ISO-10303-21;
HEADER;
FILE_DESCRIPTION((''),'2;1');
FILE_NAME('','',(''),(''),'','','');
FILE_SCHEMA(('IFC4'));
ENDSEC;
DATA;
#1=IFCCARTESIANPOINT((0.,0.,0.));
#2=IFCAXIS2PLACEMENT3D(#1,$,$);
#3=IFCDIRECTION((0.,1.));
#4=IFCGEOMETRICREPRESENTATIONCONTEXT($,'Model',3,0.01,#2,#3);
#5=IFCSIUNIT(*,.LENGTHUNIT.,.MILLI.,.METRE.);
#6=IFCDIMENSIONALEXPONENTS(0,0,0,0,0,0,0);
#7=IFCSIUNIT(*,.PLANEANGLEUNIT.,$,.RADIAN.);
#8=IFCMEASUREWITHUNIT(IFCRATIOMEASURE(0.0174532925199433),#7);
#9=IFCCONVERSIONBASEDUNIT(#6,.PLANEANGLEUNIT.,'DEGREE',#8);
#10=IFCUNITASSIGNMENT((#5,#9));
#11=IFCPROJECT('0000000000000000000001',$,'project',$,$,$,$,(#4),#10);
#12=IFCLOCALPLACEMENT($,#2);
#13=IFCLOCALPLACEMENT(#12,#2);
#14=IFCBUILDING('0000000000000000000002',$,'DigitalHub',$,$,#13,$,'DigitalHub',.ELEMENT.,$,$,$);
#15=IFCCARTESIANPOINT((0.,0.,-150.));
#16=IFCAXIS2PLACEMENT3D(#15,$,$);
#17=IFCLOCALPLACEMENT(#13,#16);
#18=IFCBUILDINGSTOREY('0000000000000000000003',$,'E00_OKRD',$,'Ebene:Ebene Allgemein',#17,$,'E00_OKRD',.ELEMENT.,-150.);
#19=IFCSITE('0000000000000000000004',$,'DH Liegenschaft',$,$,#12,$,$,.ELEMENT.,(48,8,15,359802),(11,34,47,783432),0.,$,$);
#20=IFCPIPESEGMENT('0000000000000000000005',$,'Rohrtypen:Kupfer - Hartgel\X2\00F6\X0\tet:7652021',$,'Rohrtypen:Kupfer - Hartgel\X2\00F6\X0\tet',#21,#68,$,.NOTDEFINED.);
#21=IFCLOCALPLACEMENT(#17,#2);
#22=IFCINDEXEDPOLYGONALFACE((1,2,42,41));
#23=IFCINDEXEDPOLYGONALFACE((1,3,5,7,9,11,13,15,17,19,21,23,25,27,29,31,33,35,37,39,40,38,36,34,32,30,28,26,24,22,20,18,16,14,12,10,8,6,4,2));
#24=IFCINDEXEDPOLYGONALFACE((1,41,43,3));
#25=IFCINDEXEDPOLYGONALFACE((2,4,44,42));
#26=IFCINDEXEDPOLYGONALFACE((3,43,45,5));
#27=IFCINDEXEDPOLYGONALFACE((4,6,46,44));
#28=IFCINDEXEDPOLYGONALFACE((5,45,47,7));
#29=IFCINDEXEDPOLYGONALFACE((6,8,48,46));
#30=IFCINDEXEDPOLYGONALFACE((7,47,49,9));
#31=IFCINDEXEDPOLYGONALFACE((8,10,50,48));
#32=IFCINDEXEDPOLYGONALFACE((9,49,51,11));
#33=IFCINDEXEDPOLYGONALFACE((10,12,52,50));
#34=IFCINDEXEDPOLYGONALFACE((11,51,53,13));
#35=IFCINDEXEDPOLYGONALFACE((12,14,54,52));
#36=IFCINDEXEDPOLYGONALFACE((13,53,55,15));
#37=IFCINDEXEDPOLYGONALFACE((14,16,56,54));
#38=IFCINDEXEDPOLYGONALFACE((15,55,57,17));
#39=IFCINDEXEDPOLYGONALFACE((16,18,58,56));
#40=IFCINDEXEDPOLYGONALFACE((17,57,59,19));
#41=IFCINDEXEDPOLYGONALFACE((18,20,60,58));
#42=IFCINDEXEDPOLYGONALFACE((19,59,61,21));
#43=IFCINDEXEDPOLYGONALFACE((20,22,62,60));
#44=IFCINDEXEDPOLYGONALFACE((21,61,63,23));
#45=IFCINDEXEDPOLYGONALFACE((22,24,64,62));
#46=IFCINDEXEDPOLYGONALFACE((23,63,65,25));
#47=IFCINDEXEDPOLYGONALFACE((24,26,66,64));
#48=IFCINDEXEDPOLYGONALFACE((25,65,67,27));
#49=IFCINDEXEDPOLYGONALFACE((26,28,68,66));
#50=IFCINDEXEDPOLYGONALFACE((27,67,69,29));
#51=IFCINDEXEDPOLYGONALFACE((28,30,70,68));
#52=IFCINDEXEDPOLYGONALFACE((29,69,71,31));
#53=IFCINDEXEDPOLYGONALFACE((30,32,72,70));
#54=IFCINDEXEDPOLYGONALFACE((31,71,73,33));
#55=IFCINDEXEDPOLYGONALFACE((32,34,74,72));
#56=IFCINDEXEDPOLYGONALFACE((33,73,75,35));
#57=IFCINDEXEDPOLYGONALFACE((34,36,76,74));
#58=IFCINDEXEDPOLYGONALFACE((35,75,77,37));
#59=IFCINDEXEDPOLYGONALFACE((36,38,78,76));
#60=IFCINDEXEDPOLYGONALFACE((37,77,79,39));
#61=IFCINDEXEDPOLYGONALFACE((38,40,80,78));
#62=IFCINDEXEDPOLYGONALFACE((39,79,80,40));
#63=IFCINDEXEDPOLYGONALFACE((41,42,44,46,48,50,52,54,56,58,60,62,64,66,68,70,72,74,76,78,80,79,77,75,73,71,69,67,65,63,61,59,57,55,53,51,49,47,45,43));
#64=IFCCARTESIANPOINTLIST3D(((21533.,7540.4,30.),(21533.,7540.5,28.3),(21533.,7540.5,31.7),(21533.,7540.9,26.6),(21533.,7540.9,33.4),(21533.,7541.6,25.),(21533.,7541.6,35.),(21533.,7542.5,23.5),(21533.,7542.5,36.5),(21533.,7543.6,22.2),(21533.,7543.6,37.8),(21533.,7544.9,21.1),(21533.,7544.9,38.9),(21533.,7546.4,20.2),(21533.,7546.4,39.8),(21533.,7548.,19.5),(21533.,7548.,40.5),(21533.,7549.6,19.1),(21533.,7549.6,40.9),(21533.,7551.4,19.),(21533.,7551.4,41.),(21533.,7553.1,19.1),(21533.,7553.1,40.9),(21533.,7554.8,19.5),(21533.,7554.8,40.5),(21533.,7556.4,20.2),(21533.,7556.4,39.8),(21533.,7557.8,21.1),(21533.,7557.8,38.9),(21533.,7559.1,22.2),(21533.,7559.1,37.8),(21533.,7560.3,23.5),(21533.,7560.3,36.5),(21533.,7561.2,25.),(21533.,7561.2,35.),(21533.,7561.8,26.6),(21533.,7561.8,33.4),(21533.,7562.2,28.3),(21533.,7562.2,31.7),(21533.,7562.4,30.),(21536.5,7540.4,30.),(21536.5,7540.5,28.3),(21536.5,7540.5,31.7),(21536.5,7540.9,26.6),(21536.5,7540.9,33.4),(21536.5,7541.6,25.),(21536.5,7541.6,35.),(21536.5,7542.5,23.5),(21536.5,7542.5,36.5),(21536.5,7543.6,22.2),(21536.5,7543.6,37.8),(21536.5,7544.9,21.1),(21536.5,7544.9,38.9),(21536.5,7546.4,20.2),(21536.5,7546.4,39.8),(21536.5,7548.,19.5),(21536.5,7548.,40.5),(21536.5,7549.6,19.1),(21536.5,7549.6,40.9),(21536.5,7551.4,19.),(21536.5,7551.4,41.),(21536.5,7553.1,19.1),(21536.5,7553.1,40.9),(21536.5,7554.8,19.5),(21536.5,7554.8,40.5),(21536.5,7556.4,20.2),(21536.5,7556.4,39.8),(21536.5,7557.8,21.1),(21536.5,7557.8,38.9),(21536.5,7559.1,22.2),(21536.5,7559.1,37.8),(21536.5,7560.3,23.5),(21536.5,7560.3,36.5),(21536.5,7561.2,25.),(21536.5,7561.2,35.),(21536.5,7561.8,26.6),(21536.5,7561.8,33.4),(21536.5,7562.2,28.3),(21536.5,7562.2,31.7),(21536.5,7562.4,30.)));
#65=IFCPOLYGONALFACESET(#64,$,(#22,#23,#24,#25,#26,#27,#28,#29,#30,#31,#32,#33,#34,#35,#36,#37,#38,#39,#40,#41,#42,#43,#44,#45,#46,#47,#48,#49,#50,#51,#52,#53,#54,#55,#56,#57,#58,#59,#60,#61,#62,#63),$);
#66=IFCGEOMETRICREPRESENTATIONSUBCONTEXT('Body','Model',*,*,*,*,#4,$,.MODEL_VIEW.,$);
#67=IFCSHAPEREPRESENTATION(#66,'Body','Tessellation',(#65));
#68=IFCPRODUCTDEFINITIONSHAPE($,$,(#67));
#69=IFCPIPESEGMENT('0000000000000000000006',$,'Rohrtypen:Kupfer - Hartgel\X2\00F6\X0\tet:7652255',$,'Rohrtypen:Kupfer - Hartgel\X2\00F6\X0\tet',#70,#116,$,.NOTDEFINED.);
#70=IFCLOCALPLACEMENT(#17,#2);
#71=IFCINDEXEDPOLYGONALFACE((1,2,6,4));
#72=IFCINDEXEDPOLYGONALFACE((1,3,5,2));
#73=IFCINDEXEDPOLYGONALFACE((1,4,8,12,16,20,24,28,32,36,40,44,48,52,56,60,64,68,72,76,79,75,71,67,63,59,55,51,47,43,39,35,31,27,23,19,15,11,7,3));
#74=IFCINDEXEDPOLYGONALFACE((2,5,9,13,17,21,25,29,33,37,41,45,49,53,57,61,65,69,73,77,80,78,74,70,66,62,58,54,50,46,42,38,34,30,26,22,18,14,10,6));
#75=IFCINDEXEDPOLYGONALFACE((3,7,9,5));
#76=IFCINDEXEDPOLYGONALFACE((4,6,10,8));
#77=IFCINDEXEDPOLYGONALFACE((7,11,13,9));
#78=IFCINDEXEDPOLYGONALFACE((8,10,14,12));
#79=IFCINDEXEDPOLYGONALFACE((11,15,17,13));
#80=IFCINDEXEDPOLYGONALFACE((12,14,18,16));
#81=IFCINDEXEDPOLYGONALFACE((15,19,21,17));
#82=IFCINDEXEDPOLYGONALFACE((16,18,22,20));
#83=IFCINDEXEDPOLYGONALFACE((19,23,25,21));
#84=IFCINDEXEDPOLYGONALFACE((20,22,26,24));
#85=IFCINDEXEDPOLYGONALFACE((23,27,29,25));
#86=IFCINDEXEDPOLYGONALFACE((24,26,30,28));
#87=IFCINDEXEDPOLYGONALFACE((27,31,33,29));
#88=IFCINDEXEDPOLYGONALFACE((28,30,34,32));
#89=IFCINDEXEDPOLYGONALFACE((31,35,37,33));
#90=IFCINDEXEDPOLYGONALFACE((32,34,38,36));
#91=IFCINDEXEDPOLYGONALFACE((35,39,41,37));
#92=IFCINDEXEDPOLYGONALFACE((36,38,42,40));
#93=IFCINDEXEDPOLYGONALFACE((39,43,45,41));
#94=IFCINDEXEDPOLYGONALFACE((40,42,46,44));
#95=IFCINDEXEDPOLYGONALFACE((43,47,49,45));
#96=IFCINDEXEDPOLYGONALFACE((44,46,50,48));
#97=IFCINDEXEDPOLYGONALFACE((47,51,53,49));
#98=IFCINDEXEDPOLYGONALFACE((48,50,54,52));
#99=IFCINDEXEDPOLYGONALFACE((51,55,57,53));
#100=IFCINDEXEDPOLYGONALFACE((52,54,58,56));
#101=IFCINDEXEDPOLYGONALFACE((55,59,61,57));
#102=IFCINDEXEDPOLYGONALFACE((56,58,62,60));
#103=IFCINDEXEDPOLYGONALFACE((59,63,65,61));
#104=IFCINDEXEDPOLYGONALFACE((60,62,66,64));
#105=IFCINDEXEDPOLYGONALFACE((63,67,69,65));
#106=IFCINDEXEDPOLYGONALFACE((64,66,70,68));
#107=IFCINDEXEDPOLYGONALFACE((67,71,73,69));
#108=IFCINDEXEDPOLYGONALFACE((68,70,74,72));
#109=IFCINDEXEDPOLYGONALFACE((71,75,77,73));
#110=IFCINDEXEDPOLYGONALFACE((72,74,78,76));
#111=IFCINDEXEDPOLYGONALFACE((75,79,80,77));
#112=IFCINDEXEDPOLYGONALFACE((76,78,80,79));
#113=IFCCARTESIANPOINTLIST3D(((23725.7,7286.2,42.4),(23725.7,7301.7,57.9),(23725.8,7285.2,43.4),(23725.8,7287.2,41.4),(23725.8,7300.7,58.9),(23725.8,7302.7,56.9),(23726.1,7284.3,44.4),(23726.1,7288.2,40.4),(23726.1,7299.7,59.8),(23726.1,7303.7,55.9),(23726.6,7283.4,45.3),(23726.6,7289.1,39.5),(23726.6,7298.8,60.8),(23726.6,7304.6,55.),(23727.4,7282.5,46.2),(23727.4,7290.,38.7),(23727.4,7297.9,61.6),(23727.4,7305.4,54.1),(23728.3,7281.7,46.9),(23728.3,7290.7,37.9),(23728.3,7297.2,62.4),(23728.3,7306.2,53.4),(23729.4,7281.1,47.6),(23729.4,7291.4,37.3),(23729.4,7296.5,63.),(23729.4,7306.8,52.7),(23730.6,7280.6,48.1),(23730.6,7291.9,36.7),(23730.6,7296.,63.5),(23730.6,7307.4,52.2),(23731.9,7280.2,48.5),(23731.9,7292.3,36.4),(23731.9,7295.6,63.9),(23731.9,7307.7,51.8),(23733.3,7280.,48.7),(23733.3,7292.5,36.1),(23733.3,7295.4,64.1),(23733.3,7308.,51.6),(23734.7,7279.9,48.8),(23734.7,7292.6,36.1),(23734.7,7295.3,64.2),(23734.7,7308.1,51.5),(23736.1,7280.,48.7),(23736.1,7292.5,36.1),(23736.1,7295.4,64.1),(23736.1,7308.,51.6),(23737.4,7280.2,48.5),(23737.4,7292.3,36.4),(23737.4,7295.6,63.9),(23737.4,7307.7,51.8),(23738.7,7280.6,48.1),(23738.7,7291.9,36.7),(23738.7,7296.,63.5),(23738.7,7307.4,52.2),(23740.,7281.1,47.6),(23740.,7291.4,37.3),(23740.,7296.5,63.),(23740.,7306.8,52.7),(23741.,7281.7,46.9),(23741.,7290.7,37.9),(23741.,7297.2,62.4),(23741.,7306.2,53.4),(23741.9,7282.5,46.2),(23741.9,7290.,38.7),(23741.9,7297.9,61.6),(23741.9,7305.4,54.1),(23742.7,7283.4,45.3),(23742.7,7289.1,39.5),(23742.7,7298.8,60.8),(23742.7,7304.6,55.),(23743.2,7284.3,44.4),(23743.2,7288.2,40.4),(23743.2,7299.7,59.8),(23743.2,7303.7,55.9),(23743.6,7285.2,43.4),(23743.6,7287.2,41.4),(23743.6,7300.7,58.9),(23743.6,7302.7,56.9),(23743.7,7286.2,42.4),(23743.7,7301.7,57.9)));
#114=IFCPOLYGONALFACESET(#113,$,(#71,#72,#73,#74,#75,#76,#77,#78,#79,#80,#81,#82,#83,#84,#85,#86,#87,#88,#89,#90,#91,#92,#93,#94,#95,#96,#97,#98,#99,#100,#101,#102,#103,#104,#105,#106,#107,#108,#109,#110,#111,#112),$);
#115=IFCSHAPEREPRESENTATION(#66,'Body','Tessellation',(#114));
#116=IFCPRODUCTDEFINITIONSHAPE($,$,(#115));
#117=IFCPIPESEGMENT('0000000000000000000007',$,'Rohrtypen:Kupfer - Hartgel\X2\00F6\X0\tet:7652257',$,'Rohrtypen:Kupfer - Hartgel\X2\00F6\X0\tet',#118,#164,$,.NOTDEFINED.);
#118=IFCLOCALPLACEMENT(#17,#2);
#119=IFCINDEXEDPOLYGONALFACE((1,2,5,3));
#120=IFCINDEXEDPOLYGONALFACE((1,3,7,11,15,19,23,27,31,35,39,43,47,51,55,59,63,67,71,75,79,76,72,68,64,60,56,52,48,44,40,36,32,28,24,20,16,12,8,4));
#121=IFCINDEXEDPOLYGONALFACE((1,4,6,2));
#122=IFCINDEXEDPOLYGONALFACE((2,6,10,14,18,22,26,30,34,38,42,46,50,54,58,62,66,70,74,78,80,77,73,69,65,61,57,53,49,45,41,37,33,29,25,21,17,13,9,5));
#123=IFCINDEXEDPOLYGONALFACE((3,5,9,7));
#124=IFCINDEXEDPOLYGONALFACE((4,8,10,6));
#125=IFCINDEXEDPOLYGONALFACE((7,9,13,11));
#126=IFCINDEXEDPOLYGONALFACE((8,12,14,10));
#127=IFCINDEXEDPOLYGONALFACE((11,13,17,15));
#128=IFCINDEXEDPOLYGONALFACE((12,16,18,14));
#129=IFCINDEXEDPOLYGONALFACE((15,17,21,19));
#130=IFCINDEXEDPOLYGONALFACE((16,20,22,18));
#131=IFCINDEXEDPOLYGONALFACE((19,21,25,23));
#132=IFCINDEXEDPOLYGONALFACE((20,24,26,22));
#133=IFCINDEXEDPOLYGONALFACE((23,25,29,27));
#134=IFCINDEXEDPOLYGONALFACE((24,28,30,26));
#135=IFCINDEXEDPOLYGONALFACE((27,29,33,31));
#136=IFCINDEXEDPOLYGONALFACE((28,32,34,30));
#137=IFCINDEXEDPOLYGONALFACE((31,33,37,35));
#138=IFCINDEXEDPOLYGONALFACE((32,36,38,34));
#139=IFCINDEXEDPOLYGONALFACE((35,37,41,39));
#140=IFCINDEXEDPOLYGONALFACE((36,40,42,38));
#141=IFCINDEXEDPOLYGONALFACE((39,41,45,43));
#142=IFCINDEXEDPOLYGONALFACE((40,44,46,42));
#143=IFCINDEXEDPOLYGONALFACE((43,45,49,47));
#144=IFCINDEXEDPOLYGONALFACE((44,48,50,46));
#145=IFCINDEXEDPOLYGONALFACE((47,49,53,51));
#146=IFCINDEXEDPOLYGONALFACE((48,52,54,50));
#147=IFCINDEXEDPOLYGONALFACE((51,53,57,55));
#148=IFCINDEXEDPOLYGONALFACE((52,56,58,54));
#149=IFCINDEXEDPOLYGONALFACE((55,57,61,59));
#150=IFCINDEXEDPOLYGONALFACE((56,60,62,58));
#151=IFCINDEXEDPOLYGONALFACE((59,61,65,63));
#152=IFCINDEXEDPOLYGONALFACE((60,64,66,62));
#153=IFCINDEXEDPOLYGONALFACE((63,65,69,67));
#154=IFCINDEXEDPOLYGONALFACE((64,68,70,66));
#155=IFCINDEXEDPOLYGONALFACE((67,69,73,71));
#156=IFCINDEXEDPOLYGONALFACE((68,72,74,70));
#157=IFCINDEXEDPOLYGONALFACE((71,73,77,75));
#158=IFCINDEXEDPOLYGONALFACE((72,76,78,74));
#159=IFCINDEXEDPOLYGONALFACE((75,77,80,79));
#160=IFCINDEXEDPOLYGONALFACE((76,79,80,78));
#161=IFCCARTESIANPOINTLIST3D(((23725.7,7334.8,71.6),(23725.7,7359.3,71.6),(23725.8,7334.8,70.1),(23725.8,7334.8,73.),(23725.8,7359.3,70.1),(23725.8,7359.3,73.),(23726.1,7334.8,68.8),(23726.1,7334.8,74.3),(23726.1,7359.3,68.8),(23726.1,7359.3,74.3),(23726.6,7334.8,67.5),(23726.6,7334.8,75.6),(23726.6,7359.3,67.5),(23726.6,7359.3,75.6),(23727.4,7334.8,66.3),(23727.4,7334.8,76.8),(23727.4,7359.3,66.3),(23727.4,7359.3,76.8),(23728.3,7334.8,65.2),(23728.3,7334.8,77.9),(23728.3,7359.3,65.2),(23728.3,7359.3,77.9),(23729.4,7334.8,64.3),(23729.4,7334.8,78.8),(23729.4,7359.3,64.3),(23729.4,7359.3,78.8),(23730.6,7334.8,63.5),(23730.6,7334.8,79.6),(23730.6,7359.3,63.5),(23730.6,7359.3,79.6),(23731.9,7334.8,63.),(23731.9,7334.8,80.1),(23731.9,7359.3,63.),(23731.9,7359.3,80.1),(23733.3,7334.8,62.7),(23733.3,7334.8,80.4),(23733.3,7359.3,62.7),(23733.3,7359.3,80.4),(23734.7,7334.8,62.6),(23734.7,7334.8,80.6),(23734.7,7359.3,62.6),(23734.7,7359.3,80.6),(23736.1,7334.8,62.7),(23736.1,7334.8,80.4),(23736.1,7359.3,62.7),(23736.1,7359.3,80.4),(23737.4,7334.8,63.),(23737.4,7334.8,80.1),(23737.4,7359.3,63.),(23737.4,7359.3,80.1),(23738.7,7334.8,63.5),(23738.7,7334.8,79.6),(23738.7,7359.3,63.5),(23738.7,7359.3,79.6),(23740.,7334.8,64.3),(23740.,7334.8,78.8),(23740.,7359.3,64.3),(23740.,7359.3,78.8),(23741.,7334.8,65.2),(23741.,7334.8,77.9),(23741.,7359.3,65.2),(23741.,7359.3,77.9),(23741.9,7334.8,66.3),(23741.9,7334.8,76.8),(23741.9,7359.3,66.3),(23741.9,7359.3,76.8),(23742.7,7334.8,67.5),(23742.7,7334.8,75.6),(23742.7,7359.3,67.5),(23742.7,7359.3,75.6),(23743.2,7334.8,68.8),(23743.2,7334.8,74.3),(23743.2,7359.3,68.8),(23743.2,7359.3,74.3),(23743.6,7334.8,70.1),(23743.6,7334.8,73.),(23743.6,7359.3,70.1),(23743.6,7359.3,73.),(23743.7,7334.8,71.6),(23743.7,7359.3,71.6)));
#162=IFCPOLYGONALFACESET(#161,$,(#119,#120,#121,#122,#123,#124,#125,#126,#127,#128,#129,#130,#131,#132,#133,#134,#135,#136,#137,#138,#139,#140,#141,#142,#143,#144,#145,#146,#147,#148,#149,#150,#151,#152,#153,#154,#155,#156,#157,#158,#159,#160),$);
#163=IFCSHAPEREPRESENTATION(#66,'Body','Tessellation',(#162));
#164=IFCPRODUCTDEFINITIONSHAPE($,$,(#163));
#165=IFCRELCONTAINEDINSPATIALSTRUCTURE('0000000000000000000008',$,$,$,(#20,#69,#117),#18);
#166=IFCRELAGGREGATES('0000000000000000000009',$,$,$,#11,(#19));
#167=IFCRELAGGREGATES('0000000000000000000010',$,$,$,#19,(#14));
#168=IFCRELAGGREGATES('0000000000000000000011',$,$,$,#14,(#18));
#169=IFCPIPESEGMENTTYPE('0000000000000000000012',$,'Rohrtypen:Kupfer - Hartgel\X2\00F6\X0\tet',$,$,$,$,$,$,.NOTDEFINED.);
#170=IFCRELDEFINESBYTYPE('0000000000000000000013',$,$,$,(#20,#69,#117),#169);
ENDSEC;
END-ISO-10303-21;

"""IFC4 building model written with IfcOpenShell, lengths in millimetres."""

from ifc_helpers import new_model, entity, si_unit, converted_unit, direction, frame, origin, place, context, subcontext, project, spatial, indexed_curve, outline, extrude, type_object, element, save


model = new_model("IFC4")

# Units and contexts
model_context = context("Model", 3, precision=0.01, world=origin(), true_north=direction((0.0, 1.0)))
body_context = subcontext(model_context, "Body", "Model", "MODEL_VIEW")
ifc_project = project(units=[si_unit("LENGTHUNIT", "METRE", prefix="MILLI"), converted_unit("PLANEANGLEUNIT", "DEGREE", entity("IfcRatioMeasure", 0.0174532925199433), si_unit("PLANEANGLEUNIT", "RADIAN"), dimensions=[0, 0, 0, 0, 0, 0, 0])], contexts=[model_context])

# Site, building, storey
site_placement = place(None, origin())
site = spatial("IfcSite", under=ifc_project, at=site_placement, Name="DH Liegenschaft", CompositionType="ELEMENT", RefLatitude=(48, 8, 15, 359802), RefLongitude=(11, 34, 47, 783432), RefElevation=0.0)
building_placement = place(site_placement, origin())
building = spatial("IfcBuilding", under=site, at=building_placement, Name="DigitalHub", LongName="DigitalHub", CompositionType="ELEMENT")
storey_placement = place(building_placement, frame((0.0, 0.0, -150.0)))
storey = spatial("IfcBuildingStorey", under=building, at=storey_placement, Name="E00_OKRD", ObjectType="Ebene:Ebene Allgemein", LongName="E00_OKRD", CompositionType="ELEMENT", Elevation=-150.0)

# Pipe segments
pipe_segment_type = type_object("IfcPipeSegmentType", Name="Rohrtypen:Kupfer - Hartgelötet", PredefinedType="NOTDEFINED")
pipe_segment_1_placement = place(storey_placement, frame((21533.0, 7538.8, 17.4)))
element("IfcPipeSegment", 1, at=pipe_segment_1_placement, inside=storey, type_object=pipe_segment_type, Name="Rohrtypen:Kupfer - Hartgelötet:7652021", ObjectType="Rohrtypen:Kupfer - Hartgelötet", PredefinedType="NOTDEFINED", context=body_context, shape_type="SweptSolid", body=[
    extrude(outline(indexed_curve([(11.0, 0.0), (10.9, 1.7), (10.5, 3.4), (9.8, 5.0), (8.9, 6.5), (7.8, 7.8), (6.5, 8.9), (5.0, 9.8), (3.4, 10.5), (1.7, 10.9), (0.0, 11.0), (-1.7, 10.9), (-3.4, 10.5), (-5.0, 9.8), (-6.5, 8.9), (-7.8, 7.8), (-8.9, 6.5), (-9.8, 5.0), (-10.5, 3.4), (-10.9, 1.7), (-11.0, 0.0), (-10.9, -1.7), (-10.5, -3.4), (-9.8, -5.0), (-8.9, -6.5), (-7.8, -7.8), (-6.5, -8.9), (-5.0, -9.8), (-3.4, -10.5), (-1.7, -10.9), (0.0, -11.0), (1.7, -10.9), (3.4, -10.5), (5.0, -9.8), (6.5, -8.9), (7.8, -7.8), (8.9, -6.5), (9.8, -5.0), (10.5, -3.4), (10.9, -1.7), (11.0, 0.0)], self_intersect=False)), frame((0.0, 12.6, 12.6), z_axis=(1.0, 0.0, 0.0), x_axis=(0.0, -1.0, 0.0)), (0.0, 0.0, 1.0), 3.5),
])
pipe_segment_2_placement = place(storey_placement, frame((23724.1, 7278.3, 34.5)))
element("IfcPipeSegment", 2, at=pipe_segment_2_placement, inside=storey, type_object=pipe_segment_type, Name="Rohrtypen:Kupfer - Hartgelötet:7652255", ObjectType="Rohrtypen:Kupfer - Hartgelötet", PredefinedType="NOTDEFINED", context=body_context, shape_type="SweptSolid", body=[
    extrude(outline(indexed_curve([(9.0, 0.0), (8.9, 1.4), (8.6, 2.8), (8.0, 4.1), (7.3, 5.3), (6.4, 6.4), (5.3, 7.3), (4.1, 8.0), (2.8, 8.6), (1.4, 8.9), (0.0, 9.0), (-1.4, 8.9), (-2.8, 8.6), (-4.1, 8.0), (-5.3, 7.3), (-6.4, 6.4), (-7.3, 5.3), (-8.0, 4.1), (-8.6, 2.8), (-8.9, 1.4), (-9.0, 0.0), (-8.9, -1.4), (-8.6, -2.8), (-8.0, -4.1), (-7.3, -5.3), (-6.4, -6.4), (-5.3, -7.3), (-4.1, -8.0), (-2.8, -8.6), (-1.4, -8.9), (0.0, -9.0), (1.4, -8.9), (2.8, -8.6), (4.1, -8.0), (5.3, -7.3), (6.4, -6.4), (7.3, -5.3), (8.0, -4.1), (8.6, -2.8), (8.9, -1.4), (9.0, 0.0)], self_intersect=False)), frame((10.6, 8.0, 8.0), z_axis=(0.0, 0.707107, 0.707107), x_axis=(1.0, 0.0, 0.0)), (0.0, 0.0, 1.0), 21.8),
])
pipe_segment_3_placement = place(storey_placement, frame((23724.1, 7334.8, 61.0)))
element("IfcPipeSegment", 3, at=pipe_segment_3_placement, inside=storey, type_object=pipe_segment_type, Name="Rohrtypen:Kupfer - Hartgelötet:7652257", ObjectType="Rohrtypen:Kupfer - Hartgelötet", PredefinedType="NOTDEFINED", context=body_context, shape_type="SweptSolid", body=[
    extrude(outline(indexed_curve([(9.0, 0.0), (8.9, 1.4), (8.6, 2.8), (8.0, 4.1), (7.3, 5.3), (6.4, 6.4), (5.3, 7.3), (4.1, 8.0), (2.8, 8.6), (1.4, 8.9), (0.0, 9.0), (-1.4, 8.9), (-2.8, 8.6), (-4.1, 8.0), (-5.3, 7.3), (-6.4, 6.4), (-7.3, 5.3), (-8.0, 4.1), (-8.6, 2.8), (-8.9, 1.4), (-9.0, 0.0), (-8.9, -1.4), (-8.6, -2.8), (-8.0, -4.1), (-7.3, -5.3), (-6.4, -6.4), (-5.3, -7.3), (-4.1, -8.0), (-2.8, -8.6), (-1.4, -8.9), (0.0, -9.0), (1.4, -8.9), (2.8, -8.6), (4.1, -8.0), (5.3, -7.3), (6.4, -6.4), (7.3, -5.3), (8.0, -4.1), (8.6, -2.8), (8.9, -1.4), (9.0, 0.0)], self_intersect=False)), frame((10.6, 24.6, 10.6), z_axis=(0.0, -1.0, 0.000282), x_axis=(-1.0, 0.0, 0.0)), (0.0, 0.0, 1.0), 24.6),
])

save(model, "model.ifc")
